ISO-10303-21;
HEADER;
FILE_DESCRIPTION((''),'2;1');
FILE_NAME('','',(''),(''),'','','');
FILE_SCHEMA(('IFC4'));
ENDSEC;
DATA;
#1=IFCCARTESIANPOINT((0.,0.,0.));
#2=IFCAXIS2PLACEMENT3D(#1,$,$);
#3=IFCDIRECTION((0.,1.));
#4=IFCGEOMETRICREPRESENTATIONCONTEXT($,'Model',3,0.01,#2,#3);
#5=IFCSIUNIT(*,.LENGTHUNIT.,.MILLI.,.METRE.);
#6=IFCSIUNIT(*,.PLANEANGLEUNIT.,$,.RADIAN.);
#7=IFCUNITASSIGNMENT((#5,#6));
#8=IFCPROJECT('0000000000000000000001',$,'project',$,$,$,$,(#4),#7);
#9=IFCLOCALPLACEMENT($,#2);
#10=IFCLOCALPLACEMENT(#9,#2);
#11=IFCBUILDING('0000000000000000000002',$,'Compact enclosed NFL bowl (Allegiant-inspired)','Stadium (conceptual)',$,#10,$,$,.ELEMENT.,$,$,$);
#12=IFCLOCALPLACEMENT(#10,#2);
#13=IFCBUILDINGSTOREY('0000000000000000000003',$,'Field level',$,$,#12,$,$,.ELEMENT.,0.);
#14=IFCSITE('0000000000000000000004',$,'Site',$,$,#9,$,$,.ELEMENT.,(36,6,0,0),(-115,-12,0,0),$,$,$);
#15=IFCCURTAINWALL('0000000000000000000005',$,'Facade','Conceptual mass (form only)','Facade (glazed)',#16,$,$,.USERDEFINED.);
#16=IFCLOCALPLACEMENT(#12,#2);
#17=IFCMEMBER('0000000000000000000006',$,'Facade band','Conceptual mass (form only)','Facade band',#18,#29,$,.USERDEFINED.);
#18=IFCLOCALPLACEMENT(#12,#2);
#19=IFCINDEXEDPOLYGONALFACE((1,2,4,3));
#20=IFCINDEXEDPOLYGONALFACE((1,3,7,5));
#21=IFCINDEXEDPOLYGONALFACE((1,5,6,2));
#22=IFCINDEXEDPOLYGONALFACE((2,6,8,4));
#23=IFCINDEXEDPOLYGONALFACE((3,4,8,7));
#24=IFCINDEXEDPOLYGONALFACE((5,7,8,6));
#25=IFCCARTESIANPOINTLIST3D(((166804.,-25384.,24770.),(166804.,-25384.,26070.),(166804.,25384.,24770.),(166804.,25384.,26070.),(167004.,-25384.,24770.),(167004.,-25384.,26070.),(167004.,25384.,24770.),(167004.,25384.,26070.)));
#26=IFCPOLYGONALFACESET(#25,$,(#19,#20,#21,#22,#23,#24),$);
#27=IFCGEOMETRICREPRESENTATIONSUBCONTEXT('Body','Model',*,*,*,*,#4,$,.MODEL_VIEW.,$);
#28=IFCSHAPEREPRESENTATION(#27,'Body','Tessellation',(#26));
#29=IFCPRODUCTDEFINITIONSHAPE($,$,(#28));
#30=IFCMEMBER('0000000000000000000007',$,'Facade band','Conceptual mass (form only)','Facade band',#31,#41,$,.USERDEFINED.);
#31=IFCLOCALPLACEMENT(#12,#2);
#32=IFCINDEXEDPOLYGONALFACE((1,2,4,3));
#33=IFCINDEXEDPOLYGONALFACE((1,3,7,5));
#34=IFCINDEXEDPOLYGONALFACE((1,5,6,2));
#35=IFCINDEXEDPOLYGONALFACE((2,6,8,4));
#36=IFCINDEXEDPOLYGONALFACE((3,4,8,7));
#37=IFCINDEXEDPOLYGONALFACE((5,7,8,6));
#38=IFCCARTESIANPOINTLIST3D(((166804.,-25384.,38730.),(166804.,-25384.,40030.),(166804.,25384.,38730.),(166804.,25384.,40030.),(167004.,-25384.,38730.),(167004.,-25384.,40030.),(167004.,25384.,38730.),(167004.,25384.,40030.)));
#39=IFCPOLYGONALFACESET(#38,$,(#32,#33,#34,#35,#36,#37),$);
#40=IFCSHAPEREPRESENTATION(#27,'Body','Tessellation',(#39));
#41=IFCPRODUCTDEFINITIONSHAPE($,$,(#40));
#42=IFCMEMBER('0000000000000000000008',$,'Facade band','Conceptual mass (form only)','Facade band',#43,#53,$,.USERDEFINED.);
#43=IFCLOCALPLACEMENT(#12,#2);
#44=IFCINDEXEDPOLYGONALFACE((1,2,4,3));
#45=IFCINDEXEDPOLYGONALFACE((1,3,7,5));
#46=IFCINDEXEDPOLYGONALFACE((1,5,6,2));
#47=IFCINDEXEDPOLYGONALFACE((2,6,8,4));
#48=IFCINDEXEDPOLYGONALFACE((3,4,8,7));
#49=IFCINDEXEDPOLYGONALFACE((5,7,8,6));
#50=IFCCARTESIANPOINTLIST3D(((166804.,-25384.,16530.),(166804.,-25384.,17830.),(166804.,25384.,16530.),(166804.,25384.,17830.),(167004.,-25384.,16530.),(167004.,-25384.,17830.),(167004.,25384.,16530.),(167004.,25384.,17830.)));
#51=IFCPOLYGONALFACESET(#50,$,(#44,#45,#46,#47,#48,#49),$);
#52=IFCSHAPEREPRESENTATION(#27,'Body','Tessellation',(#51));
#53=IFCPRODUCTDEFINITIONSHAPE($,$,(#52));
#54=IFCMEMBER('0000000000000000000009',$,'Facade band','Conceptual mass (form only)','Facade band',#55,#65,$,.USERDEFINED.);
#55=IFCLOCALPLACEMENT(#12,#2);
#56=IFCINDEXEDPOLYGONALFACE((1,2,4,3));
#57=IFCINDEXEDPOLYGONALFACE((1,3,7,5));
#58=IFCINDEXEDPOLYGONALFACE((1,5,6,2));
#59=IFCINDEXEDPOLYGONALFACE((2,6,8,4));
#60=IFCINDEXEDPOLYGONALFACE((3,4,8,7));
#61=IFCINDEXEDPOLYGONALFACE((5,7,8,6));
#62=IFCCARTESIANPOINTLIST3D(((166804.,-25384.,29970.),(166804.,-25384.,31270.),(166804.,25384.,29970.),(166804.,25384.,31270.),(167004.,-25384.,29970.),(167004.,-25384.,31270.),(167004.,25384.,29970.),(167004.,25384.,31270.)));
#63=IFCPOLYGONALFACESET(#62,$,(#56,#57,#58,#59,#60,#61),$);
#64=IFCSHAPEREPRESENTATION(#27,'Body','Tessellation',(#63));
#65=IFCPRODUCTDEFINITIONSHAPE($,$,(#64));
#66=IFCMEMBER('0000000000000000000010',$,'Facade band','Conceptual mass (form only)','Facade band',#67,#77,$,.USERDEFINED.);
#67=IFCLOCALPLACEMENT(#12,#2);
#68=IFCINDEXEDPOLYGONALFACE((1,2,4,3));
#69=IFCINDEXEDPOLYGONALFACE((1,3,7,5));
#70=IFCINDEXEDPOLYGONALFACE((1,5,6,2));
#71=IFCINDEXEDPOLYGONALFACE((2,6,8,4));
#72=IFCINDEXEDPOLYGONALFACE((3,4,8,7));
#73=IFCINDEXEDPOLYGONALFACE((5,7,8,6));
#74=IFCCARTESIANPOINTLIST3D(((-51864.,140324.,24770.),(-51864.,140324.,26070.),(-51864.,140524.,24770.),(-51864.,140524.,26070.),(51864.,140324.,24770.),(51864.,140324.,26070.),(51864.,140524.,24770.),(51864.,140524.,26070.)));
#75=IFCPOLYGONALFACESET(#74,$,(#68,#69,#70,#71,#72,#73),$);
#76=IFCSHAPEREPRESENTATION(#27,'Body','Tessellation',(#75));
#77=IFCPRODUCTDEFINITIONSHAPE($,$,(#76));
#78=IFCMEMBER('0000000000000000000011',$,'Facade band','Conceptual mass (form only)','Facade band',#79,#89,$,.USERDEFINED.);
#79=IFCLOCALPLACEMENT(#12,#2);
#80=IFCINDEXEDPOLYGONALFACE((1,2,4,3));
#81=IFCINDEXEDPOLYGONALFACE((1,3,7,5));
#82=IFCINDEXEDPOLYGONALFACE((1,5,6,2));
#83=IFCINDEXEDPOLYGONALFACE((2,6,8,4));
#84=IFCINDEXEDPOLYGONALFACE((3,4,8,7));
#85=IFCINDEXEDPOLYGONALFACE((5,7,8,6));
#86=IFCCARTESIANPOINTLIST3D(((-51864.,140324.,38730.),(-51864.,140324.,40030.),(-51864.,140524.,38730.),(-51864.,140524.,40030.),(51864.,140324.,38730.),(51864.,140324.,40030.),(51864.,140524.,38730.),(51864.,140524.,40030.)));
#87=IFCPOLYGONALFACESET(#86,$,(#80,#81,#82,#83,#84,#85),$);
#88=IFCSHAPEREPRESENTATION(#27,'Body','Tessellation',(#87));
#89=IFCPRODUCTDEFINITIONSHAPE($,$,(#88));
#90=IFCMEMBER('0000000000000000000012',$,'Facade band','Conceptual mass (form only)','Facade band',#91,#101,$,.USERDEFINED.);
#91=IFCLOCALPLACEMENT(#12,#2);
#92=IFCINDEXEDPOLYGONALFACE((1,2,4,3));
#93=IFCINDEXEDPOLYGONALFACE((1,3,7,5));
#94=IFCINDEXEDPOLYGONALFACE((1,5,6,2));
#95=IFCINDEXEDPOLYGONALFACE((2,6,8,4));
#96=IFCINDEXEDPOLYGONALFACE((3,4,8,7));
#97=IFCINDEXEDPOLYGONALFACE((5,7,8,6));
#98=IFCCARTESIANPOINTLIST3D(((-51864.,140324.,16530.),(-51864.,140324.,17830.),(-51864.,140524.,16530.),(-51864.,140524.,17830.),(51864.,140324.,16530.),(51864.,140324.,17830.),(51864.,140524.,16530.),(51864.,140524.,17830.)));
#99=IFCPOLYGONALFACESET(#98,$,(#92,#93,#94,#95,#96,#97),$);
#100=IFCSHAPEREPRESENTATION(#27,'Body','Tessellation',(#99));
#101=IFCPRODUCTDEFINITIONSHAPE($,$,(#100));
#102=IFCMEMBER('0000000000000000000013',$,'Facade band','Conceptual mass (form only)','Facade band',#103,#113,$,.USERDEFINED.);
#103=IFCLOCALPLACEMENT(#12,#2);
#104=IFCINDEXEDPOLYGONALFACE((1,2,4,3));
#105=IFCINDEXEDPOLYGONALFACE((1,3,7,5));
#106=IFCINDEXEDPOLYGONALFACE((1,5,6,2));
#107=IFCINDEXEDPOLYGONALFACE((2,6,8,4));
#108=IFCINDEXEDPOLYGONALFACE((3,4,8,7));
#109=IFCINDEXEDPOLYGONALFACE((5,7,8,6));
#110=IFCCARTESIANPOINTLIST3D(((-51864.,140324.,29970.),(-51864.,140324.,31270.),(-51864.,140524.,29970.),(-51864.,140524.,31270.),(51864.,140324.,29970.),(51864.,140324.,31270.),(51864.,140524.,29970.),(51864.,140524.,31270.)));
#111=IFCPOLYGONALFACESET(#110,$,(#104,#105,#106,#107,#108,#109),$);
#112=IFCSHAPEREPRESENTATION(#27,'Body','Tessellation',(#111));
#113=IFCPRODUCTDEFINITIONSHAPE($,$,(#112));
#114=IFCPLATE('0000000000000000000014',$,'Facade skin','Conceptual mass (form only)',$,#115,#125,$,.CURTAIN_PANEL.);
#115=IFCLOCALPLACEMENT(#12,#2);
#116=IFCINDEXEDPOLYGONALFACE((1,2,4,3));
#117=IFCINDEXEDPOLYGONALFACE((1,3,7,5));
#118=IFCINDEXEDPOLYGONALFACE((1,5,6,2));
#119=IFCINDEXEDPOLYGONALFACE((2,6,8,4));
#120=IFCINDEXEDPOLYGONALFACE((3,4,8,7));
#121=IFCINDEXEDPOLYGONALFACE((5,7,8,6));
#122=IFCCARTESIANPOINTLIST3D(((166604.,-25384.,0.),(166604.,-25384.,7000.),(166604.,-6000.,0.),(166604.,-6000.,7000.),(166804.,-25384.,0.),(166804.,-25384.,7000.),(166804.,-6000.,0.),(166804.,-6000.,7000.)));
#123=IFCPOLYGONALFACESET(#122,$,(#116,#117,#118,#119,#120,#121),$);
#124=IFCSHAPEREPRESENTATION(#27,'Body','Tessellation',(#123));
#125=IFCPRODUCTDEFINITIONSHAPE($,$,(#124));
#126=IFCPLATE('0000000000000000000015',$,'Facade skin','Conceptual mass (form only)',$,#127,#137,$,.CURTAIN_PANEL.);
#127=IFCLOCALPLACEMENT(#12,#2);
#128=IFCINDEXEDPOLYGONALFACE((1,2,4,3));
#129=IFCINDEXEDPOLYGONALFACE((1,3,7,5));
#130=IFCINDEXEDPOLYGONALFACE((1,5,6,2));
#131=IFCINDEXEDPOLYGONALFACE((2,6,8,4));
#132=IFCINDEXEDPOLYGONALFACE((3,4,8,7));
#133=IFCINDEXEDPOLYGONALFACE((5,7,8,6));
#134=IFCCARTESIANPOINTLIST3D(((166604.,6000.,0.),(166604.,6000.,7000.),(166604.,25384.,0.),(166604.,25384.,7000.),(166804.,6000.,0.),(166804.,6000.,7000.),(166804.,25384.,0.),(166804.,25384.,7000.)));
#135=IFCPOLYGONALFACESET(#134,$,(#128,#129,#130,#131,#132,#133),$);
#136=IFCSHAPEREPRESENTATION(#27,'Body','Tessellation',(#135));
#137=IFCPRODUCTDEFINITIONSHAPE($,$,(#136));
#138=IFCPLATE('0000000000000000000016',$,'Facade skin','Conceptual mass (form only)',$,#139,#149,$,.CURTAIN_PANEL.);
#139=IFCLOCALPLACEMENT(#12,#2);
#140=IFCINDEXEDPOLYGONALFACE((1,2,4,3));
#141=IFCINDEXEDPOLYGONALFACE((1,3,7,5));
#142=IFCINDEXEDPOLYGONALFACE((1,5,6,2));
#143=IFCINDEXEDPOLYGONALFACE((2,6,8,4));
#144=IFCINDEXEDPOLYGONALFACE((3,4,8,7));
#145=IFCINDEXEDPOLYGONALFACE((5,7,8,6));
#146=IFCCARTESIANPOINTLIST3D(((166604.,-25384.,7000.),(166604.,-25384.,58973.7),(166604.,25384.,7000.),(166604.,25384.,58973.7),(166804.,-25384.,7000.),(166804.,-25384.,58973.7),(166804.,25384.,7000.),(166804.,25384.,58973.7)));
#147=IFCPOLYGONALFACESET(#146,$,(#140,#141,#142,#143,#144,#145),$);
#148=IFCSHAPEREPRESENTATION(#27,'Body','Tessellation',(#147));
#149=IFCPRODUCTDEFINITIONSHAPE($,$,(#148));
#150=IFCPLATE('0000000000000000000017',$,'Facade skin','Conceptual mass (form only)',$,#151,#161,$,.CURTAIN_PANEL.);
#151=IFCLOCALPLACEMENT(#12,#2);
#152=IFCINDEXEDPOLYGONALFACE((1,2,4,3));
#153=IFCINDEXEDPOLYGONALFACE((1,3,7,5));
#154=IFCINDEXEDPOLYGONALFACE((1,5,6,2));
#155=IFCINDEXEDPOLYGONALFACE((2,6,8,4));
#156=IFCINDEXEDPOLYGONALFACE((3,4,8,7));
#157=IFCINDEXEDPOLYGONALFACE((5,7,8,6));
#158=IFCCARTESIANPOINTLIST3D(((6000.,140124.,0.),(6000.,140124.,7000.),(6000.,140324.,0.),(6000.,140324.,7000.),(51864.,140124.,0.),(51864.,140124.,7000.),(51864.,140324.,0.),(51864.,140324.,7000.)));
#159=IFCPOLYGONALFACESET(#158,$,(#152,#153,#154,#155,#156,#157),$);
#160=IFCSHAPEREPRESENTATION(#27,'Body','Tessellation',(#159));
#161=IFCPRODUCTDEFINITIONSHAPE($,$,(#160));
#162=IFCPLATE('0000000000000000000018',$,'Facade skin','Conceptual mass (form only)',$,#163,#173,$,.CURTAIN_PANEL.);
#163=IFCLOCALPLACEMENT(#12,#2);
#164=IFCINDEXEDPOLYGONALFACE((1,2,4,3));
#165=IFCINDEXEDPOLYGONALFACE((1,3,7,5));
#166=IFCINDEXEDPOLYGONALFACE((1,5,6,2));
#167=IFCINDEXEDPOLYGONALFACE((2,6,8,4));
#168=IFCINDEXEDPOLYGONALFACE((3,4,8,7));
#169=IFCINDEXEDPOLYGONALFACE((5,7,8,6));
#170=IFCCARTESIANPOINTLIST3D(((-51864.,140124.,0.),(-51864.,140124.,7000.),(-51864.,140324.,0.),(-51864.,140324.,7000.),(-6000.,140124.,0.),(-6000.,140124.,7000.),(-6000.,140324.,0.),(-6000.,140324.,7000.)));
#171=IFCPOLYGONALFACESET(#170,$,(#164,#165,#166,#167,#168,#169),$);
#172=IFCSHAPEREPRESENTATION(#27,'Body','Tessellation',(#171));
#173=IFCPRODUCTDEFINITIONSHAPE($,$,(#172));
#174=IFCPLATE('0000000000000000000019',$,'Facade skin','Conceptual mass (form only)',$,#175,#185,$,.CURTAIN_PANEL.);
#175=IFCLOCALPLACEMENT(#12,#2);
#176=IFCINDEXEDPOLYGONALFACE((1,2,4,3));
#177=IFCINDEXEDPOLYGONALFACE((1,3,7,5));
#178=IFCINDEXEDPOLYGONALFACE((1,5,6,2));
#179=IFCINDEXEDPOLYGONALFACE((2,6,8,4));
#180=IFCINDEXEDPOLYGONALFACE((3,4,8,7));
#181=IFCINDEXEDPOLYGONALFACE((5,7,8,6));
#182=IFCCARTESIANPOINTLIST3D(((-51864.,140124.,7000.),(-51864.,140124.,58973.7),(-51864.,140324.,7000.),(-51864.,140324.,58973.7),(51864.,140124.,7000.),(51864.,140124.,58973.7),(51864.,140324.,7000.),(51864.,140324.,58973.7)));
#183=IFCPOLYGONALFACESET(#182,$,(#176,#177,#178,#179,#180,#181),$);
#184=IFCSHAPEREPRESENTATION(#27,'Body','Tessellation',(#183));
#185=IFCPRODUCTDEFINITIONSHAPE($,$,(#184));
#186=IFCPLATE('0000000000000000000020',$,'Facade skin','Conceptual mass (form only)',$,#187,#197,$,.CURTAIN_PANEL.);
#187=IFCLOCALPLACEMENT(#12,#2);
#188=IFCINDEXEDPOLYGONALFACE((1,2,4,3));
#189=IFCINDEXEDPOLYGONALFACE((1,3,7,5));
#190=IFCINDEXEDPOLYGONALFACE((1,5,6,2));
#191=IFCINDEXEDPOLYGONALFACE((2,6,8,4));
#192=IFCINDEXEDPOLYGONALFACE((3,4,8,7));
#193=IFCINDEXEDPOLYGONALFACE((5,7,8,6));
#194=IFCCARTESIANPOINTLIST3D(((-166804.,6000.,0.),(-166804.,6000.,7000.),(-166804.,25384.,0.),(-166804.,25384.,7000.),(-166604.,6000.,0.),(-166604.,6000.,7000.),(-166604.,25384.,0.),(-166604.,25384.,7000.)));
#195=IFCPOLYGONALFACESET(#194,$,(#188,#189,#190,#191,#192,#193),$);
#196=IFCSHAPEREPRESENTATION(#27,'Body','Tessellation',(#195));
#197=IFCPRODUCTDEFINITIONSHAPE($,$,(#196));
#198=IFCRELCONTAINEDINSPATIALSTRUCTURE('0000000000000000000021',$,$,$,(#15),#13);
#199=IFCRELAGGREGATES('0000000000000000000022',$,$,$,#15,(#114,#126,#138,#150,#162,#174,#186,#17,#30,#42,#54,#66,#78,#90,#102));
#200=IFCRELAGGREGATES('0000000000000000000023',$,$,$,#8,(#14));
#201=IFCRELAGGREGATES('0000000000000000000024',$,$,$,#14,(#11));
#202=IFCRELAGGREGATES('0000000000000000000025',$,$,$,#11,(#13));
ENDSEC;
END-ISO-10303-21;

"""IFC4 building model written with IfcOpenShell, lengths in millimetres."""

from ifc_helpers import new_model, si_unit, direction, frame, origin, place, context, subcontext, project, spatial, line, indexed_curve, outline, extrude, element, aggregate, save


model = new_model("IFC4")

# Units and contexts
model_context = context("Model", 3, precision=0.01, world=origin(), true_north=direction((0.0, 1.0)))
body_context = subcontext(model_context, "Body", "Model", "MODEL_VIEW")
ifc_project = project(units=[si_unit("LENGTHUNIT", "METRE", prefix="MILLI"), si_unit("PLANEANGLEUNIT", "RADIAN")], contexts=[model_context])

# Site, building, storey
site_placement = place(None, origin())
site = spatial("IfcSite", under=ifc_project, at=site_placement, Name="Site", CompositionType="ELEMENT", RefLatitude=(36, 6, 0, 0), RefLongitude=(-115, -12, 0, 0))
building_placement = place(site_placement, origin())
building = spatial("IfcBuilding", under=site, at=building_placement, Name="Compact enclosed NFL bowl (Allegiant-inspired)", Description="Stadium (conceptual)", CompositionType="ELEMENT")
storey_placement = place(building_placement, origin())
storey = spatial("IfcBuildingStorey", under=building, at=storey_placement, Name="Field level", CompositionType="ELEMENT", Elevation=0.0)

# Curtain wall, members, plates
placement_1 = place(storey_placement, origin())
curtain_wall = element("IfcCurtainWall", 1, at=placement_1, inside=storey, Name="Facade", Description="Conceptual mass (form only)", ObjectType="Facade (glazed)", PredefinedType="USERDEFINED")
placement_2 = place(building_placement, frame((0.0, 0.0, 17530.0)))
placement_3 = place(placement_2, frame((0.0, 0.0, -17530.0)))
member_1 = element("IfcMember", 2, at=placement_3, Name="Facade band", Description="Conceptual mass (form only)", ObjectType="Facade band", PredefinedType="USERDEFINED", context=body_context, shape_type="SweptSolid", body=[
    extrude(outline(indexed_curve([(166804.0, -25384.0), (166804.0, 25384.0), (167004.0, 25384.0), (167004.0, -25384.0)], segments=[line(1, 2), line(2, 3), line(3, 4), line(4, 1)], self_intersect=False)), frame((0.0, 0.0, 24770.0)), (0.0, 0.0, 1.0), 1300.0),
])
placement_4 = place(building_placement, frame((0.0, 0.0, 30970.0)))
placement_5 = place(placement_4, frame((0.0, 0.0, -30970.0)))
member_2 = element("IfcMember", 3, at=placement_5, Name="Facade band", Description="Conceptual mass (form only)", ObjectType="Facade band", PredefinedType="USERDEFINED", context=body_context, shape_type="SweptSolid", body=[
    extrude(outline(indexed_curve([(166804.0, -25384.0), (166804.0, 25384.0), (167004.0, 25384.0), (167004.0, -25384.0)], segments=[line(1, 2), line(2, 3), line(3, 4), line(4, 1)], self_intersect=False)), frame((0.0, 0.0, 38730.0)), (0.0, 0.0, 1.0), 1300.0),
])
placement_6 = place(building_placement, frame((0.0, 0.0, 5510.0)))
placement_7 = place(placement_6, frame((0.0, 0.0, -5510.0)))
member_3 = element("IfcMember", 4, at=placement_7, Name="Facade band", Description="Conceptual mass (form only)", ObjectType="Facade band", PredefinedType="USERDEFINED", context=body_context, shape_type="SweptSolid", body=[
    extrude(outline(indexed_curve([(166804.0, -25384.0), (166804.0, 25384.0), (167004.0, 25384.0), (167004.0, -25384.0)], segments=[line(1, 2), line(2, 3), line(3, 4), line(4, 1)], self_intersect=False)), frame((0.0, 0.0, 16530.0)), (0.0, 0.0, 1.0), 1300.0),
])
placement_8 = place(building_placement, frame((0.0, 0.0, 25770.0)))
placement_9 = place(placement_8, frame((0.0, 0.0, -25770.0)))
member_4 = element("IfcMember", 5, at=placement_9, Name="Facade band", Description="Conceptual mass (form only)", ObjectType="Facade band", PredefinedType="USERDEFINED", context=body_context, shape_type="SweptSolid", body=[
    extrude(outline(indexed_curve([(166804.0, -25384.0), (166804.0, 25384.0), (167004.0, 25384.0), (167004.0, -25384.0)], segments=[line(1, 2), line(2, 3), line(3, 4), line(4, 1)], self_intersect=False)), frame((0.0, 0.0, 29970.0)), (0.0, 0.0, 1.0), 1300.0),
])
member_5 = element("IfcMember", 6, at=placement_3, Name="Facade band", Description="Conceptual mass (form only)", ObjectType="Facade band", PredefinedType="USERDEFINED", context=body_context, shape_type="SweptSolid", body=[
    extrude(outline(indexed_curve([(51864.0, 140324.0), (-51864.0, 140324.0), (-51864.0, 140524.0), (51864.0, 140524.0)], segments=[line(1, 2), line(2, 3), line(3, 4), line(4, 1)], self_intersect=False)), frame((0.0, 0.0, 24770.0)), (0.0, 0.0, 1.0), 1300.0),
])
member_6 = element("IfcMember", 7, at=placement_5, Name="Facade band", Description="Conceptual mass (form only)", ObjectType="Facade band", PredefinedType="USERDEFINED", context=body_context, shape_type="SweptSolid", body=[
    extrude(outline(indexed_curve([(51864.0, 140324.0), (-51864.0, 140324.0), (-51864.0, 140524.0), (51864.0, 140524.0)], segments=[line(1, 2), line(2, 3), line(3, 4), line(4, 1)], self_intersect=False)), frame((0.0, 0.0, 38730.0)), (0.0, 0.0, 1.0), 1300.0),
])
member_7 = element("IfcMember", 8, at=placement_7, Name="Facade band", Description="Conceptual mass (form only)", ObjectType="Facade band", PredefinedType="USERDEFINED", context=body_context, shape_type="SweptSolid", body=[
    extrude(outline(indexed_curve([(51864.0, 140324.0), (-51864.0, 140324.0), (-51864.0, 140524.0), (51864.0, 140524.0)], segments=[line(1, 2), line(2, 3), line(3, 4), line(4, 1)], self_intersect=False)), frame((0.0, 0.0, 16530.0)), (0.0, 0.0, 1.0), 1300.0),
])
member_8 = element("IfcMember", 9, at=placement_9, Name="Facade band", Description="Conceptual mass (form only)", ObjectType="Facade band", PredefinedType="USERDEFINED", context=body_context, shape_type="SweptSolid", body=[
    extrude(outline(indexed_curve([(51864.0, 140324.0), (-51864.0, 140324.0), (-51864.0, 140524.0), (51864.0, 140524.0)], segments=[line(1, 2), line(2, 3), line(3, 4), line(4, 1)], self_intersect=False)), frame((0.0, 0.0, 29970.0)), (0.0, 0.0, 1.0), 1300.0),
])
plate_1 = element("IfcPlate", 10, at=placement_1, Name="Facade skin", Description="Conceptual mass (form only)", PredefinedType="CURTAIN_PANEL", context=body_context, shape_type="SweptSolid", body=[
    extrude(outline(indexed_curve([(166604.0, -25384.0), (166604.0, -6000.0), (166804.0, -6000.0), (166804.0, -25384.0)], segments=[line(1, 2), line(2, 3), line(3, 4), line(4, 1)], self_intersect=False)), origin(), (0.0, 0.0, 1.0), 7000.0),
])
plate_2 = element("IfcPlate", 11, at=placement_1, Name="Facade skin", Description="Conceptual mass (form only)", PredefinedType="CURTAIN_PANEL", context=body_context, shape_type="SweptSolid", body=[
    extrude(outline(indexed_curve([(166604.0, 6000.0), (166604.0, 25384.0), (166804.0, 25384.0), (166804.0, 6000.0)], segments=[line(1, 2), line(2, 3), line(3, 4), line(4, 1)], self_intersect=False)), origin(), (0.0, 0.0, 1.0), 7000.0),
])
plate_3 = element("IfcPlate", 12, at=placement_7, Name="Facade skin", Description="Conceptual mass (form only)", PredefinedType="CURTAIN_PANEL", context=body_context, shape_type="SweptSolid", body=[
    extrude(outline(indexed_curve([(166604.0, -25384.0), (166604.0, 25384.0), (166804.0, 25384.0), (166804.0, -25384.0)], segments=[line(1, 2), line(2, 3), line(3, 4), line(4, 1)], self_intersect=False)), frame((0.0, 0.0, 7000.0)), (0.0, 0.0, 1.0), 51973.7),
])
plate_4 = element("IfcPlate", 13, at=placement_1, Name="Facade skin", Description="Conceptual mass (form only)", PredefinedType="CURTAIN_PANEL", context=body_context, shape_type="SweptSolid", body=[
    extrude(outline(indexed_curve([(51864.0, 140124.0), (6000.0, 140124.0), (6000.0, 140324.0), (51864.0, 140324.0)], segments=[line(1, 2), line(2, 3), line(3, 4), line(4, 1)], self_intersect=False)), origin(), (0.0, 0.0, 1.0), 7000.0),
])
plate_5 = element("IfcPlate", 14, at=placement_1, Name="Facade skin", Description="Conceptual mass (form only)", PredefinedType="CURTAIN_PANEL", context=body_context, shape_type="SweptSolid", body=[
    extrude(outline(indexed_curve([(-6000.0, 140124.0), (-51864.0, 140124.0), (-51864.0, 140324.0), (-6000.0, 140324.0)], segments=[line(1, 2), line(2, 3), line(3, 4), line(4, 1)], self_intersect=False)), origin(), (0.0, 0.0, 1.0), 7000.0),
])
plate_6 = element("IfcPlate", 15, at=placement_7, Name="Facade skin", Description="Conceptual mass (form only)", PredefinedType="CURTAIN_PANEL", context=body_context, shape_type="SweptSolid", body=[
    extrude(outline(indexed_curve([(51864.0, 140124.0), (-51864.0, 140124.0), (-51864.0, 140324.0), (51864.0, 140324.0)], segments=[line(1, 2), line(2, 3), line(3, 4), line(4, 1)], self_intersect=False)), frame((0.0, 0.0, 7000.0)), (0.0, 0.0, 1.0), 51973.7),
])
plate_7 = element("IfcPlate", 16, at=placement_1, Name="Facade skin", Description="Conceptual mass (form only)", PredefinedType="CURTAIN_PANEL", context=body_context, shape_type="SweptSolid", body=[
    extrude(outline(indexed_curve([(-166604.0, 25384.0), (-166604.0, 6000.0), (-166804.0, 6000.0), (-166804.0, 25384.0)], segments=[line(1, 2), line(2, 3), line(3, 4), line(4, 1)], self_intersect=False)), origin(), (0.0, 0.0, 1.0), 7000.0),
])
aggregate(curtain_wall, [plate_1, plate_2, plate_3, plate_4, plate_5, plate_6, plate_7, member_1, member_2, member_3, member_4, member_5, member_6, member_7, member_8])

save(model, "model.ifc")
